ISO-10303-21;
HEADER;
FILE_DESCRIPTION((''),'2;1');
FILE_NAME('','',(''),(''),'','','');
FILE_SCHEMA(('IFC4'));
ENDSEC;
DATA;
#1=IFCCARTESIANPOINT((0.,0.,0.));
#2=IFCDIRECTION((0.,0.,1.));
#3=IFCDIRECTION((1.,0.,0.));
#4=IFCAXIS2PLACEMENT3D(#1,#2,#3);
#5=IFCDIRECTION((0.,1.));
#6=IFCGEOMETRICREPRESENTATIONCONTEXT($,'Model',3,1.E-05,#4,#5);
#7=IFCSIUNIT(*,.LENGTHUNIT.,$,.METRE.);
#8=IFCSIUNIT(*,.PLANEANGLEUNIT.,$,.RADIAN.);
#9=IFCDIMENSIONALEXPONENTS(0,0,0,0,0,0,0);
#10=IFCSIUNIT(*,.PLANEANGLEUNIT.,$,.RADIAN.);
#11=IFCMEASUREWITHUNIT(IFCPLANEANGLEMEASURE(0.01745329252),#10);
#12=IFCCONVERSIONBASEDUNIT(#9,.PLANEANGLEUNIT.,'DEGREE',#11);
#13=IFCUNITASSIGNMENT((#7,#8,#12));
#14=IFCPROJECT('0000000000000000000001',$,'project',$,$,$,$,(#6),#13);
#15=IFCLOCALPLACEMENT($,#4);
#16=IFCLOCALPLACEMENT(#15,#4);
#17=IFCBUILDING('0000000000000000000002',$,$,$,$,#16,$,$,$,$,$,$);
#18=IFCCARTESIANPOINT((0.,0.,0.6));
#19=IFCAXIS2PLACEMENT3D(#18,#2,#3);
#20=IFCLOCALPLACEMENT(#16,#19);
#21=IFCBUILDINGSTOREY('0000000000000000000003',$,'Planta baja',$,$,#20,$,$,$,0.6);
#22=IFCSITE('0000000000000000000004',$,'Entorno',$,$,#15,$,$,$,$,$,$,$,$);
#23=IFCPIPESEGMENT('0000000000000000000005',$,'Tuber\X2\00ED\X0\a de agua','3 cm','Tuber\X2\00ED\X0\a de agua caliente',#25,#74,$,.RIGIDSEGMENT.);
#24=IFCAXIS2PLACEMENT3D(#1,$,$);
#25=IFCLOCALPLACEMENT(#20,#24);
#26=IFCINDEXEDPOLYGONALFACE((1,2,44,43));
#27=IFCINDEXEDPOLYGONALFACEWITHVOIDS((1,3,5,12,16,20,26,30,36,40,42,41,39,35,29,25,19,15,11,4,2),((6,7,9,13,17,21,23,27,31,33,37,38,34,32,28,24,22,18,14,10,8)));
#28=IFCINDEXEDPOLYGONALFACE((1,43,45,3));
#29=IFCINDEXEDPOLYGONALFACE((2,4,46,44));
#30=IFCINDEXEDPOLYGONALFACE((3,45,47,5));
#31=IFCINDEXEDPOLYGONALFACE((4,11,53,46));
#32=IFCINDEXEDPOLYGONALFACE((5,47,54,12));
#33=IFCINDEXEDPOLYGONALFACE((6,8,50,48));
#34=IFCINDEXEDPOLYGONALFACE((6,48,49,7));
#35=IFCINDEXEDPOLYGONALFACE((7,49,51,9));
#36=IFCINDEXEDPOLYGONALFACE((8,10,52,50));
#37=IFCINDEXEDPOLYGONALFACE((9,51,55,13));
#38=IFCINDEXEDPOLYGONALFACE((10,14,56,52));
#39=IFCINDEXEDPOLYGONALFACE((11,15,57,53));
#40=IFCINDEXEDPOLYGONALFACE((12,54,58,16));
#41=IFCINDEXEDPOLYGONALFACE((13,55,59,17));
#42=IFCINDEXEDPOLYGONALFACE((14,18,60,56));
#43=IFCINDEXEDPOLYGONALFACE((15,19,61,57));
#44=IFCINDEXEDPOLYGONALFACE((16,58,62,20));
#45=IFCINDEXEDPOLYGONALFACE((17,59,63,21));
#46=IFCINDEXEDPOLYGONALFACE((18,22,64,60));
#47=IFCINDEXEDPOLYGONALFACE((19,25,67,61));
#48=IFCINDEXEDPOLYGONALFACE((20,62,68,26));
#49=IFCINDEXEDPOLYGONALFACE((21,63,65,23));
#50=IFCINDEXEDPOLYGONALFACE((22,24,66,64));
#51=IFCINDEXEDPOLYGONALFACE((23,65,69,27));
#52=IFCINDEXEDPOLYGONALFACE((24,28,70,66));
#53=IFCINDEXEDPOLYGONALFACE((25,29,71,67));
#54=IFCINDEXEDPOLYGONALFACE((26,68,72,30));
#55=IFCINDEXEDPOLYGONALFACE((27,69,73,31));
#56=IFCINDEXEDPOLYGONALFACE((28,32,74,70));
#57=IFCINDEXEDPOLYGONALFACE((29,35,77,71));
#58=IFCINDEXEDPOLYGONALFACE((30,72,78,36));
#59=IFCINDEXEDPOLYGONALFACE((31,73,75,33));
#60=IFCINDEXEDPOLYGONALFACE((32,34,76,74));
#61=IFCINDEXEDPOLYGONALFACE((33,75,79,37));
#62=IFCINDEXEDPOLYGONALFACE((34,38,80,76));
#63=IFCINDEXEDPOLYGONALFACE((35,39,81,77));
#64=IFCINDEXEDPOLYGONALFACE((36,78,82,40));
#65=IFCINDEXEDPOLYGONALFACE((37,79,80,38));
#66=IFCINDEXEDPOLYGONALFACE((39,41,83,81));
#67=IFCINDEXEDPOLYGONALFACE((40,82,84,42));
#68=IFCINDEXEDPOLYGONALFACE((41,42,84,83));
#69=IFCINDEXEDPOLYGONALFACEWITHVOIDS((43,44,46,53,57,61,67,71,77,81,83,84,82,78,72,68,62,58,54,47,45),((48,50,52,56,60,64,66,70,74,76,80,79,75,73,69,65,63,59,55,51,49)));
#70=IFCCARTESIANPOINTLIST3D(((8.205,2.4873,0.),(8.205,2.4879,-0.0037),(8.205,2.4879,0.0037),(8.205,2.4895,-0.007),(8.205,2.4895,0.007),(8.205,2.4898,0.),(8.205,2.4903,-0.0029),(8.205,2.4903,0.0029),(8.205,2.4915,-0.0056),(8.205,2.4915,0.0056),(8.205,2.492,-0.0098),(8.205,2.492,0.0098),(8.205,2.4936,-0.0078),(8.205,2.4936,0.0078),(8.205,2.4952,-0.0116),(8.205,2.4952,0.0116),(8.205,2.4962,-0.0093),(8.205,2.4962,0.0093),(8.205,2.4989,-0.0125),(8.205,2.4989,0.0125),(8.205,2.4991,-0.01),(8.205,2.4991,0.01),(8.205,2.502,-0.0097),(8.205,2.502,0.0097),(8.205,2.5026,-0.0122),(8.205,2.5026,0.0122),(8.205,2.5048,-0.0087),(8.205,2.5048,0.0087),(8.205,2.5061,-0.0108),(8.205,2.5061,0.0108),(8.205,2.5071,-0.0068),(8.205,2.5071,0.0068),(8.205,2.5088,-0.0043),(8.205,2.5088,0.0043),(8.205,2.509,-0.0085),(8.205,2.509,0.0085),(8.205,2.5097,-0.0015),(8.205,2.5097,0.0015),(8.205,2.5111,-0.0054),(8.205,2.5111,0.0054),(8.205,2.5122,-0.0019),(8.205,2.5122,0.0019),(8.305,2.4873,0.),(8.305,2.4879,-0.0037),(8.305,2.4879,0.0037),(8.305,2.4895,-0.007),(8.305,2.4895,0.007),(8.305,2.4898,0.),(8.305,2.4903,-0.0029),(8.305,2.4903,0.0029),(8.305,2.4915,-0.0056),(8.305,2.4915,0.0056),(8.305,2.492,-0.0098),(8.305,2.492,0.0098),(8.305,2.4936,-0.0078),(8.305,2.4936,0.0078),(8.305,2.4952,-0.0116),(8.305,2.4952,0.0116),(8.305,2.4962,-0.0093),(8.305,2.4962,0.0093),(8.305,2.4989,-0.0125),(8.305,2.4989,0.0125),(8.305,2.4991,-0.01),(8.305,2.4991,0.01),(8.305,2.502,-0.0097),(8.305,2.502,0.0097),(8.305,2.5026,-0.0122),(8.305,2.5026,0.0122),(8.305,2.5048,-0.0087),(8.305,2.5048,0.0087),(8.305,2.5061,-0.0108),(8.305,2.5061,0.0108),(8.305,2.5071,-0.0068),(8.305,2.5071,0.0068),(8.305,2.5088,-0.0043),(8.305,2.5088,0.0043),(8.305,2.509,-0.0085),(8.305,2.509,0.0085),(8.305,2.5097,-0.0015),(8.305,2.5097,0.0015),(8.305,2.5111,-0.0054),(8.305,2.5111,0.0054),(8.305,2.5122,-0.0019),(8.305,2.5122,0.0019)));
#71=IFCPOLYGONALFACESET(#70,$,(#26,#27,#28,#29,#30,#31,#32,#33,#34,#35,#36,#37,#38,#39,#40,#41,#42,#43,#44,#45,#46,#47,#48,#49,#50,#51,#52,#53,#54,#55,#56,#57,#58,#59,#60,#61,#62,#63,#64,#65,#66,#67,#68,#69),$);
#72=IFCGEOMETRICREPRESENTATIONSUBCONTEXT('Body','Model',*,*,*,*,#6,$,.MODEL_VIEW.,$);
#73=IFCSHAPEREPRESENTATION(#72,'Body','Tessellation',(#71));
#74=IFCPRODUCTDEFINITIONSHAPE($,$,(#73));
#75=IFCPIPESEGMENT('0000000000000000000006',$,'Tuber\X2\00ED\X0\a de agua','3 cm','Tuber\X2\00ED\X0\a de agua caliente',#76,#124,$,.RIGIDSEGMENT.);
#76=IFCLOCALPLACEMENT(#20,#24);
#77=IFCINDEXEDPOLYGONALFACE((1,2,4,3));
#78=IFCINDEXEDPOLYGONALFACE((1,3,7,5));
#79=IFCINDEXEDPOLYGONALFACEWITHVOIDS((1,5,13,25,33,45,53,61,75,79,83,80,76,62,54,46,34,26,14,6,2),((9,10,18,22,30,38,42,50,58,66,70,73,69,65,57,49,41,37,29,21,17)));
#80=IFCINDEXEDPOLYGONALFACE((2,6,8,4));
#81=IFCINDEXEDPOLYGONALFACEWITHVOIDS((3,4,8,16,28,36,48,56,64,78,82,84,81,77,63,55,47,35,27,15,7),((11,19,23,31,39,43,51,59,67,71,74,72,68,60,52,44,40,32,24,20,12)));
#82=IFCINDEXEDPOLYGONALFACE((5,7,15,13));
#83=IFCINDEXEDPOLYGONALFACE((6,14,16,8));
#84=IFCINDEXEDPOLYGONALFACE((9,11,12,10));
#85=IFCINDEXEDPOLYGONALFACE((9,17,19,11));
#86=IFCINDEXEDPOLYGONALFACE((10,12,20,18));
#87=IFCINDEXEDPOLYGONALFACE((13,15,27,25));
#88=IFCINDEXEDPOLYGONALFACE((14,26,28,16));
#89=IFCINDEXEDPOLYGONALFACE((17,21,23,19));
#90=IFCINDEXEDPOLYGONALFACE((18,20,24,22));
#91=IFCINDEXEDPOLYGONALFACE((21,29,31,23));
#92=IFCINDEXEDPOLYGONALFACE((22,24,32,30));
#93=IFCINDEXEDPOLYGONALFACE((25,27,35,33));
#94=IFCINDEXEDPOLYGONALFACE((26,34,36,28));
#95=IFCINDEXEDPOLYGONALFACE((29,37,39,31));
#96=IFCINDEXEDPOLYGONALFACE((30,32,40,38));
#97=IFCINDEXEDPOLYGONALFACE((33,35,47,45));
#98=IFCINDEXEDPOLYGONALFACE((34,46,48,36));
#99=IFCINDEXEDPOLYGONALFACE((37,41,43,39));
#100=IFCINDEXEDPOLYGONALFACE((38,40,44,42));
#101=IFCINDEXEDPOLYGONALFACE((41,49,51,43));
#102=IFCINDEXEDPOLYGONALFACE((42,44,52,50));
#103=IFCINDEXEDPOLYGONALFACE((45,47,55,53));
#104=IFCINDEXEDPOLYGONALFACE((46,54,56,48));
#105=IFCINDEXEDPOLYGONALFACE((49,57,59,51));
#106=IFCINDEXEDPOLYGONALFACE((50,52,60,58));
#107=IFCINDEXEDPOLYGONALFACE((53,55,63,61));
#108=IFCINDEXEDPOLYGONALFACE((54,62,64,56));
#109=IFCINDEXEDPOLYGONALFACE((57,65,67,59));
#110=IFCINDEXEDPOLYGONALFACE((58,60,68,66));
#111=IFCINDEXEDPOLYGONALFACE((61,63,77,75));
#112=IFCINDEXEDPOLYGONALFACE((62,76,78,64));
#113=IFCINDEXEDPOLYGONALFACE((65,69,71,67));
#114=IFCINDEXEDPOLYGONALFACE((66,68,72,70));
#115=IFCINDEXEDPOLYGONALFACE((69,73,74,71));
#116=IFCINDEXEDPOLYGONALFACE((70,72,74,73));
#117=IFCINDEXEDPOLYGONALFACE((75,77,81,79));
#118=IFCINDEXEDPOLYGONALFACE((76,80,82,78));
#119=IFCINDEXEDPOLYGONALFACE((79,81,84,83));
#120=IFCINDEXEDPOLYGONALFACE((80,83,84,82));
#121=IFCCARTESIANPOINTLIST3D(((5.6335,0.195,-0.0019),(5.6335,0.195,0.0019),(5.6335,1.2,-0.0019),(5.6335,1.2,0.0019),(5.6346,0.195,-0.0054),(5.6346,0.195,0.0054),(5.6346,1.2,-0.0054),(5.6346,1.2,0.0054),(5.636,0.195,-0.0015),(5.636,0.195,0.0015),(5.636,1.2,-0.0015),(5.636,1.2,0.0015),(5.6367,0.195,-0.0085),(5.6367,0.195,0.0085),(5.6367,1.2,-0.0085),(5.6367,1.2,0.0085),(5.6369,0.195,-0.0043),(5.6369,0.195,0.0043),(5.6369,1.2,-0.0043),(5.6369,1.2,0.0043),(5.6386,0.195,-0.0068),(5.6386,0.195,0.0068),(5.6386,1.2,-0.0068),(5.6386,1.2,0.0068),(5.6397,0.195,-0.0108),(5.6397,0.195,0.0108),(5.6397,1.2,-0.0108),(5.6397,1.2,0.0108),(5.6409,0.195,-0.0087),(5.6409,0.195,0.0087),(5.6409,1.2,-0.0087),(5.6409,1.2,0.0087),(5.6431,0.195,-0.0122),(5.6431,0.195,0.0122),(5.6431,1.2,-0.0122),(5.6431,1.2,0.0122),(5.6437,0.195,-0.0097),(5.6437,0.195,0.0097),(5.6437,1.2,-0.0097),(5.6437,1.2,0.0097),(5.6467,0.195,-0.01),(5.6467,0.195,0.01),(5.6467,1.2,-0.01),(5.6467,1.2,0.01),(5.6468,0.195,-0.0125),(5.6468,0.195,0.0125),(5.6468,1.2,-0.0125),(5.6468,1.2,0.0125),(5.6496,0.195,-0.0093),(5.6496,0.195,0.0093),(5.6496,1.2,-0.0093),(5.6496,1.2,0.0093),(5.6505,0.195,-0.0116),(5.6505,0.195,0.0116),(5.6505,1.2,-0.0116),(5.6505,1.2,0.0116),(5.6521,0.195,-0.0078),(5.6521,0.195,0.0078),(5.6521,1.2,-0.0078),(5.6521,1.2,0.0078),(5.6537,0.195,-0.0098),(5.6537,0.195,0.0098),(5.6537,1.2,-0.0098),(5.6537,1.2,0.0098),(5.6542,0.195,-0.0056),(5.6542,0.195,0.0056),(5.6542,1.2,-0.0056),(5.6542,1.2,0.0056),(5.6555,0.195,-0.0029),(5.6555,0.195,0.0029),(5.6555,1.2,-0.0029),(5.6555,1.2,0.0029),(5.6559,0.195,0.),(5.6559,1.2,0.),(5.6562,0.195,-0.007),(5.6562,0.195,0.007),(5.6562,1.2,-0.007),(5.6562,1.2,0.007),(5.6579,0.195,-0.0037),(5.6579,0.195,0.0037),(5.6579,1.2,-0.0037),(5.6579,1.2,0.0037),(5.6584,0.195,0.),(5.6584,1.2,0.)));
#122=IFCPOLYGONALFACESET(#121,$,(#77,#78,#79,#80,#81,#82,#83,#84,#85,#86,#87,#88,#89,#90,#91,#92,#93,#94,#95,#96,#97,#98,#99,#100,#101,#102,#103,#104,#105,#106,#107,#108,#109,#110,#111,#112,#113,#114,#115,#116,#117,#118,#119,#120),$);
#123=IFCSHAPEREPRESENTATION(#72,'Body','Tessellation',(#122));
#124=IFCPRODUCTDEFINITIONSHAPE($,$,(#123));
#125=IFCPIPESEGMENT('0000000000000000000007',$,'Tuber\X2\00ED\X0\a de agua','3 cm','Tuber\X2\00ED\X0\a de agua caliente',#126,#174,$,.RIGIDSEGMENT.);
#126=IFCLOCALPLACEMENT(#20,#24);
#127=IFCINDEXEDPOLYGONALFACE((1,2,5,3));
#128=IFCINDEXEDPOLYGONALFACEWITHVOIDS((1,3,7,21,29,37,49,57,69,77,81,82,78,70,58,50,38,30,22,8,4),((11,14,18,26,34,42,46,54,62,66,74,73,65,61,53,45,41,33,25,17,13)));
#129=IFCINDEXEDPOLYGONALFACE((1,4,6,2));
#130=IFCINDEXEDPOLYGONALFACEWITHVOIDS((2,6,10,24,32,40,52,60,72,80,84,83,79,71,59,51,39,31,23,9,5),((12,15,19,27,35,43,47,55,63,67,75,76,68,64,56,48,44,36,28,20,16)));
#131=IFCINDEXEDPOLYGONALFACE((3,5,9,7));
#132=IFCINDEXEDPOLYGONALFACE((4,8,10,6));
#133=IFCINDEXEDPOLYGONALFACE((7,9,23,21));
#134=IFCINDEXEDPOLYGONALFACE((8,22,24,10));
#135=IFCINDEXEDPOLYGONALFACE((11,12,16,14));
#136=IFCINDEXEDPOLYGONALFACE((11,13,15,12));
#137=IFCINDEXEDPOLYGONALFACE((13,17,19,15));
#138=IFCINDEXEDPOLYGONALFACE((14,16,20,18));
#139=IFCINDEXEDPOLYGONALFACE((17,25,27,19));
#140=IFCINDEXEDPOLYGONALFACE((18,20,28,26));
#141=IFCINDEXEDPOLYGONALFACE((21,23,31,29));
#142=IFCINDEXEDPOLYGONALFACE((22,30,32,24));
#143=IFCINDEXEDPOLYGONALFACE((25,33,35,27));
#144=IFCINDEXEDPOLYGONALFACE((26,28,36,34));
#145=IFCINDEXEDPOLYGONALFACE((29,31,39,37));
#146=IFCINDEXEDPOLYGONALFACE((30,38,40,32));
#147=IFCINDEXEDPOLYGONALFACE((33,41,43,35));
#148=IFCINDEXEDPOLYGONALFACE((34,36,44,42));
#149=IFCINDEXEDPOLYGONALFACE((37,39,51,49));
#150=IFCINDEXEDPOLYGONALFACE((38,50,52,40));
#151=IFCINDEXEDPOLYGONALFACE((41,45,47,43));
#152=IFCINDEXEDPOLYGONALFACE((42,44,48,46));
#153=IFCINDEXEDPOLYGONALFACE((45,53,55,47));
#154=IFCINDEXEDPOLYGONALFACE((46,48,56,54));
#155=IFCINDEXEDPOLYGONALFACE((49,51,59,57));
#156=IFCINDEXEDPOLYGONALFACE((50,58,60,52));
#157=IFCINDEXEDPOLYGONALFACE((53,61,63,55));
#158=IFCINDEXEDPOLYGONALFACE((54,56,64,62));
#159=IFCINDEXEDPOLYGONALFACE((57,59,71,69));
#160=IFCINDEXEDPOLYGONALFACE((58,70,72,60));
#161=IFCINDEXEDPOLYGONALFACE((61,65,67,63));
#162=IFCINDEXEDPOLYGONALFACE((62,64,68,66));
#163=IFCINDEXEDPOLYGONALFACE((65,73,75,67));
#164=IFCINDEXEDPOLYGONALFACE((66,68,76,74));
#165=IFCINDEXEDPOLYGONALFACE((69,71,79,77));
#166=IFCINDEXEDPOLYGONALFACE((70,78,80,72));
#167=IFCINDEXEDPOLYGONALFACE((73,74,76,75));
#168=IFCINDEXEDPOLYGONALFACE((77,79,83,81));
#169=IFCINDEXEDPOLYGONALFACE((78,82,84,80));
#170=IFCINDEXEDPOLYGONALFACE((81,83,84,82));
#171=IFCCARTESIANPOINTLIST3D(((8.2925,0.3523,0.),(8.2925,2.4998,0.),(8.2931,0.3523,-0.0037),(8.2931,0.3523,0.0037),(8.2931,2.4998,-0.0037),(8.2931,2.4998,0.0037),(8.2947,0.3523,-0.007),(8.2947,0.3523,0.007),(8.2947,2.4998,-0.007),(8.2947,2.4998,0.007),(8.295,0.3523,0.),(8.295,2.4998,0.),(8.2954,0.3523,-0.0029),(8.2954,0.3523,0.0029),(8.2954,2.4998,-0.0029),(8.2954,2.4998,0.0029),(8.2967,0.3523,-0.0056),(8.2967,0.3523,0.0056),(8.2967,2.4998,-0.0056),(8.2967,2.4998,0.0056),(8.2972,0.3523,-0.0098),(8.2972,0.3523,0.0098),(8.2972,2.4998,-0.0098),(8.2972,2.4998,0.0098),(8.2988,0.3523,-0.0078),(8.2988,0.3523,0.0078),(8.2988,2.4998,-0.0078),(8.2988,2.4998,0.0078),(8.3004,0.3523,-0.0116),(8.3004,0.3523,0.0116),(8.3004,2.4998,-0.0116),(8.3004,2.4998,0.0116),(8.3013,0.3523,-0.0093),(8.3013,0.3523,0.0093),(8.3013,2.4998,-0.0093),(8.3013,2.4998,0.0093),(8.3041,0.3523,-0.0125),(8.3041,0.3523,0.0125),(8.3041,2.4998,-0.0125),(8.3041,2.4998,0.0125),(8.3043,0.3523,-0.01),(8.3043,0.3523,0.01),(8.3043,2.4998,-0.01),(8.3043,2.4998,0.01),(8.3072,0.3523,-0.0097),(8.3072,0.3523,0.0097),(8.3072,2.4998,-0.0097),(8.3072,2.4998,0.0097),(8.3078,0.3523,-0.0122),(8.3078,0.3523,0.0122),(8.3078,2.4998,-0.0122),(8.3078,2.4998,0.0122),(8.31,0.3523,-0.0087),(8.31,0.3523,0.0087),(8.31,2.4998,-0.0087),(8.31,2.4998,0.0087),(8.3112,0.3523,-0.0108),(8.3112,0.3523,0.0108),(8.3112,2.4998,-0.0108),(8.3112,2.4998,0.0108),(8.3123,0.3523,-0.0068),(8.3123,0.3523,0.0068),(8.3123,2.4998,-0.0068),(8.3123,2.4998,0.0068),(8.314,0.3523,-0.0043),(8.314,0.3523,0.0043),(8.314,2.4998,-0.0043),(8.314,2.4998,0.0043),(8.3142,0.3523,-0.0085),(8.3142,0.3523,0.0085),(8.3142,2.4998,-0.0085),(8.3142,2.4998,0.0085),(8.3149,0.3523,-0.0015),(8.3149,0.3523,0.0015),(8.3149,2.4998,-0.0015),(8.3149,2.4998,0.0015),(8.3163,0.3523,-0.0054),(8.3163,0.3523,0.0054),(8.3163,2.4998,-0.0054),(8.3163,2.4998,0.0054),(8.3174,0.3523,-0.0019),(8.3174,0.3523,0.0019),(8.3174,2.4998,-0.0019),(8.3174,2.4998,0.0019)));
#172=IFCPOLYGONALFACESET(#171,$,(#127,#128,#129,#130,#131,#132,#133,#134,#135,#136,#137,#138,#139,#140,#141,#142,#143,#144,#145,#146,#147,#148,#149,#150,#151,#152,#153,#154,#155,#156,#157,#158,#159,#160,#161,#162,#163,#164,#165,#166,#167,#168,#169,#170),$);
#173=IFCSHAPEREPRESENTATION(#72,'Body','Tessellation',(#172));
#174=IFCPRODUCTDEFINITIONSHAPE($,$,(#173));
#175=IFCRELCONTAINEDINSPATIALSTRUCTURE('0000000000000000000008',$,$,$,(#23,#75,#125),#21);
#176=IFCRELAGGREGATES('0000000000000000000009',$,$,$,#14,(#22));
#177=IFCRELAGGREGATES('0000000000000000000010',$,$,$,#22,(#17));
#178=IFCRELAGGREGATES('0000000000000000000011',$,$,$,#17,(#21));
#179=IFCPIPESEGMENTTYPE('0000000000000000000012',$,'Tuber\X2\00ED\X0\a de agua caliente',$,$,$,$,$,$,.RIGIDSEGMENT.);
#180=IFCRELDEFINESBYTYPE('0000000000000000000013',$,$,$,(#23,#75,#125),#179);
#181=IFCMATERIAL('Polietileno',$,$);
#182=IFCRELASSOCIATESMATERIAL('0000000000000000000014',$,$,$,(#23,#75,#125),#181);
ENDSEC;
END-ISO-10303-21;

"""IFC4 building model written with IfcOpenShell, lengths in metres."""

from ifc_helpers import new_model, entity, si_unit, converted_unit, direction, frame, origin_with_axes, origin_2d_with_axis, place, context, subcontext, project, spatial, hollow_circle, extrude, material, type_object, element, save


model = new_model("IFC4")

# Units and contexts
model_context = context("Model", 3, precision=1e-05, world=origin_with_axes(), true_north=direction((0.0, 1.0)))
body_context = subcontext(model_context, "Body", "Model", "MODEL_VIEW")
ifc_project = project(units=[si_unit("LENGTHUNIT", "METRE"), si_unit("PLANEANGLEUNIT", "RADIAN"), converted_unit("PLANEANGLEUNIT", "DEGREE", entity("IfcPlaneAngleMeasure", 0.01745329252), si_unit("PLANEANGLEUNIT", "RADIAN"), dimensions=[0, 0, 0, 0, 0, 0, 0])], contexts=[model_context])

# Site, building, storey
site_placement = place(None, origin_with_axes())
site = spatial("IfcSite", under=ifc_project, at=site_placement, Name="Entorno")
building_placement = place(site_placement, origin_with_axes())
building = spatial("IfcBuilding", under=site, at=building_placement)
storey_placement = place(building_placement, frame((0.0, 0.0, 0.6), z_axis=(0.0, 0.0, 1.0), x_axis=(1.0, 0.0, 0.0)))
storey = spatial("IfcBuildingStorey", under=building, at=storey_placement, Name="Planta baja", Elevation=0.6)

# Shared definitions
ifc_material_1 = material(Name="Polietileno")

# Pipe segments
pipe_segment_type_1 = type_object("IfcPipeSegmentType", Name="Tubería de agua caliente", PredefinedType="RIGIDSEGMENT")
pipe_segment_1_placement = place(storey_placement, frame((8.305, 2.4998, 0.0), z_axis=(-1.0, 0.0, 0.0), x_axis=(0.0, -1.0, 0.0)))
element("IfcPipeSegment", 1, at=pipe_segment_1_placement, inside=storey, type_object=pipe_segment_type_1, material=ifc_material_1, Name="Tubería de agua", Description="3 cm", ObjectType="Tubería de agua caliente", PredefinedType="RIGIDSEGMENT", context=body_context, shape_type="SweptSolid", body=[
    extrude(hollow_circle(Radius=0.0125, WallThickness=0.0025, at=origin_2d_with_axis()), origin_with_axes(), (0.0, 0.0, 1.0), 0.1),
])
pipe_segment_2_placement = place(storey_placement, frame((5.6459, 1.2, 0.0), z_axis=(0.0, -1.0, 0.0), x_axis=(1.0, 0.0, 0.0)))
element("IfcPipeSegment", 2, at=pipe_segment_2_placement, inside=storey, type_object=pipe_segment_type_1, material=ifc_material_1, Name="Tubería de agua", Description="3 cm", ObjectType="Tubería de agua caliente", PredefinedType="RIGIDSEGMENT", context=body_context, shape_type="SweptSolid", body=[
    extrude(hollow_circle(Radius=0.0125, WallThickness=0.0025, at=origin_2d_with_axis()), origin_with_axes(), (0.0, 0.0, 1.0), 1.005),
])
pipe_segment_3_placement = place(storey_placement, frame((8.305, 0.3523, 0.0), z_axis=(0.0, 1.0, 0.0), x_axis=(-1.0, 0.0, 0.0)))
element("IfcPipeSegment", 3, at=pipe_segment_3_placement, inside=storey, type_object=pipe_segment_type_1, material=ifc_material_1, Name="Tubería de agua", Description="3 cm", ObjectType="Tubería de agua caliente", PredefinedType="RIGIDSEGMENT", context=body_context, shape_type="SweptSolid", body=[
    extrude(hollow_circle(Radius=0.0125, WallThickness=0.0025, at=origin_2d_with_axis()), origin_with_axes(), (0.0, 0.0, 1.0), 2.1475),
])

save(model, "model.ifc")
